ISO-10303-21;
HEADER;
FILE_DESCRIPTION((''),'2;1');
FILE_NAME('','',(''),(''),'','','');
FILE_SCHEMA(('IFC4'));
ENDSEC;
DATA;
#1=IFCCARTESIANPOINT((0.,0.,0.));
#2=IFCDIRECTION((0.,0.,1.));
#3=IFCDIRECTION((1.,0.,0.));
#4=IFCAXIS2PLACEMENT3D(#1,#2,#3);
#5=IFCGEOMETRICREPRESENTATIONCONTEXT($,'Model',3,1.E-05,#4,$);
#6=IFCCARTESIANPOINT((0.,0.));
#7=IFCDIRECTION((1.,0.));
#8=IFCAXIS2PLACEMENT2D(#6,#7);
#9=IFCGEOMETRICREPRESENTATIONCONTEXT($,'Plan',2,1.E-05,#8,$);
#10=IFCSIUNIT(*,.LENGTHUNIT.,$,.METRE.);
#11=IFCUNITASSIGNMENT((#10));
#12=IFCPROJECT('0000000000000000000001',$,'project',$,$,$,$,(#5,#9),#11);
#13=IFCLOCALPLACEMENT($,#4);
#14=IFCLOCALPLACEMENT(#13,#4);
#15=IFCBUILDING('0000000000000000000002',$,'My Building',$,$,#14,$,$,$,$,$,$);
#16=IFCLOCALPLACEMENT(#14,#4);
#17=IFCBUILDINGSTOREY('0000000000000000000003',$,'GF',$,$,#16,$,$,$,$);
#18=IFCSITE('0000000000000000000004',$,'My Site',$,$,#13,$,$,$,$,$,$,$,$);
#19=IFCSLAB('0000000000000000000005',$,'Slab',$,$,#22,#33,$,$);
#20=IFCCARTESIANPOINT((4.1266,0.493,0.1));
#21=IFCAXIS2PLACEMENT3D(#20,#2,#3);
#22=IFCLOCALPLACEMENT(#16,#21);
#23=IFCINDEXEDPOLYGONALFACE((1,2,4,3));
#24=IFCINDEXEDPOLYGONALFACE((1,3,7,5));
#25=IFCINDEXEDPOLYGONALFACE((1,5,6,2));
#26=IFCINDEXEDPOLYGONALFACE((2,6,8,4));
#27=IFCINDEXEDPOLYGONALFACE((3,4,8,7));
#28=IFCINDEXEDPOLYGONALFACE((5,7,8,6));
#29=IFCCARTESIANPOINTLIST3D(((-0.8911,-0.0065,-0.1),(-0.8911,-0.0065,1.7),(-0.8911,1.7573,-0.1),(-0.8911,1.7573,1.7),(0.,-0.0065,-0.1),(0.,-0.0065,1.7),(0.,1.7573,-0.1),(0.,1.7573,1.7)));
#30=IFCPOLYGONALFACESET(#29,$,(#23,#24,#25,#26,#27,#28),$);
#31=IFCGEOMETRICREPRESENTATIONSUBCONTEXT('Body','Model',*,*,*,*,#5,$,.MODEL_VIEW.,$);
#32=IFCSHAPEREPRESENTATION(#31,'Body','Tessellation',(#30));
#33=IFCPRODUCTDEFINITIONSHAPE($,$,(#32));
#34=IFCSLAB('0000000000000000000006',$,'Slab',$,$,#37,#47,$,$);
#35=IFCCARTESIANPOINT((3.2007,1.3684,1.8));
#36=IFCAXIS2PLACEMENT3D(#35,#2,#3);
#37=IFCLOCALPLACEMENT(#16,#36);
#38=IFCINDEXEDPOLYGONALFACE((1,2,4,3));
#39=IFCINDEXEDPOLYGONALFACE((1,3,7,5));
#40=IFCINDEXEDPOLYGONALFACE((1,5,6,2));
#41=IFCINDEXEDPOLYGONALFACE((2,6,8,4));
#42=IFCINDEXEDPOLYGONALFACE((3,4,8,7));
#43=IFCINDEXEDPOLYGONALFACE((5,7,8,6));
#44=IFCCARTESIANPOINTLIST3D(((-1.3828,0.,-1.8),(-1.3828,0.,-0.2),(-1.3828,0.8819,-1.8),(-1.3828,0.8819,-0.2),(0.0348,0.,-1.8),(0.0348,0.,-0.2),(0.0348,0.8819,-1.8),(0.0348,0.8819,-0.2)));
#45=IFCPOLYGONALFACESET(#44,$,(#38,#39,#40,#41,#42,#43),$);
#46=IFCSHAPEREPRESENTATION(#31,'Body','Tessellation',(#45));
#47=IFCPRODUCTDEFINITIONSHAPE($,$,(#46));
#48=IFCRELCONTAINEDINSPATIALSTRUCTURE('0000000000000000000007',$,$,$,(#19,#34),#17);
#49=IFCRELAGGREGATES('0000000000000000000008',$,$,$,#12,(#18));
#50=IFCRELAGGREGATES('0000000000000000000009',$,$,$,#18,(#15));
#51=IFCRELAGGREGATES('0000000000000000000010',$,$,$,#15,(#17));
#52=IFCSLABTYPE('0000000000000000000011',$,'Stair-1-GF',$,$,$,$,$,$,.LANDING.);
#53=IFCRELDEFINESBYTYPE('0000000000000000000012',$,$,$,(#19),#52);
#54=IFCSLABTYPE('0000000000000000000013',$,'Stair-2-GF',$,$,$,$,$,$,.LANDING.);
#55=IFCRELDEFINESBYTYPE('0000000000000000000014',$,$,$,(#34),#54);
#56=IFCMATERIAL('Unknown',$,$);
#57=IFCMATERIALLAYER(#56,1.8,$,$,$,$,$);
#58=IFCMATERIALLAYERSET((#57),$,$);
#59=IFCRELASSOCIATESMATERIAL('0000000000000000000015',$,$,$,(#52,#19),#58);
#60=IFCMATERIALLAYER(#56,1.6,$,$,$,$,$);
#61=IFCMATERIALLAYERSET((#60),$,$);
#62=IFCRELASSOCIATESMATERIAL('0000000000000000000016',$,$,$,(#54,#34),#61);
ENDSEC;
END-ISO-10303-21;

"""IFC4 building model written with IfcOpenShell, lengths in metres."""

from ifc_helpers import new_model, si_unit, frame, origin_with_axes, origin_2d_with_axis, place, context, subcontext, project, spatial, indexed_curve, outline, extrude, material, layer, layer_set, layer_usage, type_object, element, save


model = new_model("IFC4")

# Units and contexts
model_context = context("Model", 3, precision=1e-05, world=origin_with_axes())
plan_context = context("Plan", 2, precision=1e-05, world=origin_2d_with_axis())
body_context_1 = subcontext(model_context, "Body", "Model", "MODEL_VIEW")
ifc_project = project(units=[si_unit("LENGTHUNIT", "METRE")], contexts=[model_context, plan_context])

# Site, building, storey
site_placement = place(None, origin_with_axes())
site = spatial("IfcSite", under=ifc_project, at=site_placement, Name="My Site")
building_placement = place(site_placement, origin_with_axes())
building = spatial("IfcBuilding", under=site, at=building_placement, Name="My Building")
storey_placement = place(building_placement, origin_with_axes())
storey = spatial("IfcBuildingStorey", under=building, at=storey_placement, Name="GF")

# Slabs
ifc_material_1 = material(Name="Unknown")
ifc_layer_1 = layer(ifc_material_1, 1.8)
ifc_layer_set_1 = layer_set([ifc_layer_1])
ifc_layer_usage_1 = layer_usage(ifc_layer_set_1, "AXIS3", "POSITIVE", -0.1)
slab_type_1 = type_object("IfcSlabType", Name="Stair-1-GF", PredefinedType="LANDING", material=ifc_layer_set_1)
slab_1_placement = place(storey_placement, frame((4.1266, 0.493, 0.1), z_axis=(0.0, 0.0, 1.0), x_axis=(1.0, 0.0, 0.0)))
element("IfcSlab", 1, at=slab_1_placement, inside=storey, type_object=slab_type_1, material=ifc_layer_usage_1, Name="Slab", context=body_context_1, shape_type="SweptSolid", body=[
    extrude(outline(indexed_curve([(0.0, -0.0065), (0.0, 1.7573), (-0.8911, 1.7573), (-0.8911, -0.0065), (0.0, -0.0065)])), frame((0.0, 0.0, -0.1), z_axis=(0.0, 0.0, 1.0), x_axis=(1.0, 0.0, 0.0)), (0.0, 0.0, 1.0), 1.8),
])
ifc_layer_2 = layer(ifc_material_1, 1.6)
ifc_layer_set_2 = layer_set([ifc_layer_2])
ifc_layer_usage_2 = layer_usage(ifc_layer_set_2, "AXIS3", "POSITIVE", -1.8)
slab_type_2 = type_object("IfcSlabType", Name="Stair-2-GF", PredefinedType="LANDING", material=ifc_layer_set_2)
slab_2_placement = place(storey_placement, frame((3.2007, 1.3684, 1.8), z_axis=(0.0, 0.0, 1.0), x_axis=(1.0, 0.0, 0.0)))
element("IfcSlab", 2, at=slab_2_placement, inside=storey, type_object=slab_type_2, material=ifc_layer_usage_2, Name="Slab", context=body_context_1, shape_type="SweptSolid", body=[
    extrude(outline(indexed_curve([(-1.3828, 0.0), (-1.3828, 0.8819), (0.0348, 0.8819), (0.0348, 0.0), (-1.3828, 0.0)])), frame((0.0, 0.0, -1.8), z_axis=(0.0, 0.0, 1.0), x_axis=(1.0, 0.0, 0.0)), (0.0, 0.0, 1.0), 1.6),
])

save(model, "model.ifc")
